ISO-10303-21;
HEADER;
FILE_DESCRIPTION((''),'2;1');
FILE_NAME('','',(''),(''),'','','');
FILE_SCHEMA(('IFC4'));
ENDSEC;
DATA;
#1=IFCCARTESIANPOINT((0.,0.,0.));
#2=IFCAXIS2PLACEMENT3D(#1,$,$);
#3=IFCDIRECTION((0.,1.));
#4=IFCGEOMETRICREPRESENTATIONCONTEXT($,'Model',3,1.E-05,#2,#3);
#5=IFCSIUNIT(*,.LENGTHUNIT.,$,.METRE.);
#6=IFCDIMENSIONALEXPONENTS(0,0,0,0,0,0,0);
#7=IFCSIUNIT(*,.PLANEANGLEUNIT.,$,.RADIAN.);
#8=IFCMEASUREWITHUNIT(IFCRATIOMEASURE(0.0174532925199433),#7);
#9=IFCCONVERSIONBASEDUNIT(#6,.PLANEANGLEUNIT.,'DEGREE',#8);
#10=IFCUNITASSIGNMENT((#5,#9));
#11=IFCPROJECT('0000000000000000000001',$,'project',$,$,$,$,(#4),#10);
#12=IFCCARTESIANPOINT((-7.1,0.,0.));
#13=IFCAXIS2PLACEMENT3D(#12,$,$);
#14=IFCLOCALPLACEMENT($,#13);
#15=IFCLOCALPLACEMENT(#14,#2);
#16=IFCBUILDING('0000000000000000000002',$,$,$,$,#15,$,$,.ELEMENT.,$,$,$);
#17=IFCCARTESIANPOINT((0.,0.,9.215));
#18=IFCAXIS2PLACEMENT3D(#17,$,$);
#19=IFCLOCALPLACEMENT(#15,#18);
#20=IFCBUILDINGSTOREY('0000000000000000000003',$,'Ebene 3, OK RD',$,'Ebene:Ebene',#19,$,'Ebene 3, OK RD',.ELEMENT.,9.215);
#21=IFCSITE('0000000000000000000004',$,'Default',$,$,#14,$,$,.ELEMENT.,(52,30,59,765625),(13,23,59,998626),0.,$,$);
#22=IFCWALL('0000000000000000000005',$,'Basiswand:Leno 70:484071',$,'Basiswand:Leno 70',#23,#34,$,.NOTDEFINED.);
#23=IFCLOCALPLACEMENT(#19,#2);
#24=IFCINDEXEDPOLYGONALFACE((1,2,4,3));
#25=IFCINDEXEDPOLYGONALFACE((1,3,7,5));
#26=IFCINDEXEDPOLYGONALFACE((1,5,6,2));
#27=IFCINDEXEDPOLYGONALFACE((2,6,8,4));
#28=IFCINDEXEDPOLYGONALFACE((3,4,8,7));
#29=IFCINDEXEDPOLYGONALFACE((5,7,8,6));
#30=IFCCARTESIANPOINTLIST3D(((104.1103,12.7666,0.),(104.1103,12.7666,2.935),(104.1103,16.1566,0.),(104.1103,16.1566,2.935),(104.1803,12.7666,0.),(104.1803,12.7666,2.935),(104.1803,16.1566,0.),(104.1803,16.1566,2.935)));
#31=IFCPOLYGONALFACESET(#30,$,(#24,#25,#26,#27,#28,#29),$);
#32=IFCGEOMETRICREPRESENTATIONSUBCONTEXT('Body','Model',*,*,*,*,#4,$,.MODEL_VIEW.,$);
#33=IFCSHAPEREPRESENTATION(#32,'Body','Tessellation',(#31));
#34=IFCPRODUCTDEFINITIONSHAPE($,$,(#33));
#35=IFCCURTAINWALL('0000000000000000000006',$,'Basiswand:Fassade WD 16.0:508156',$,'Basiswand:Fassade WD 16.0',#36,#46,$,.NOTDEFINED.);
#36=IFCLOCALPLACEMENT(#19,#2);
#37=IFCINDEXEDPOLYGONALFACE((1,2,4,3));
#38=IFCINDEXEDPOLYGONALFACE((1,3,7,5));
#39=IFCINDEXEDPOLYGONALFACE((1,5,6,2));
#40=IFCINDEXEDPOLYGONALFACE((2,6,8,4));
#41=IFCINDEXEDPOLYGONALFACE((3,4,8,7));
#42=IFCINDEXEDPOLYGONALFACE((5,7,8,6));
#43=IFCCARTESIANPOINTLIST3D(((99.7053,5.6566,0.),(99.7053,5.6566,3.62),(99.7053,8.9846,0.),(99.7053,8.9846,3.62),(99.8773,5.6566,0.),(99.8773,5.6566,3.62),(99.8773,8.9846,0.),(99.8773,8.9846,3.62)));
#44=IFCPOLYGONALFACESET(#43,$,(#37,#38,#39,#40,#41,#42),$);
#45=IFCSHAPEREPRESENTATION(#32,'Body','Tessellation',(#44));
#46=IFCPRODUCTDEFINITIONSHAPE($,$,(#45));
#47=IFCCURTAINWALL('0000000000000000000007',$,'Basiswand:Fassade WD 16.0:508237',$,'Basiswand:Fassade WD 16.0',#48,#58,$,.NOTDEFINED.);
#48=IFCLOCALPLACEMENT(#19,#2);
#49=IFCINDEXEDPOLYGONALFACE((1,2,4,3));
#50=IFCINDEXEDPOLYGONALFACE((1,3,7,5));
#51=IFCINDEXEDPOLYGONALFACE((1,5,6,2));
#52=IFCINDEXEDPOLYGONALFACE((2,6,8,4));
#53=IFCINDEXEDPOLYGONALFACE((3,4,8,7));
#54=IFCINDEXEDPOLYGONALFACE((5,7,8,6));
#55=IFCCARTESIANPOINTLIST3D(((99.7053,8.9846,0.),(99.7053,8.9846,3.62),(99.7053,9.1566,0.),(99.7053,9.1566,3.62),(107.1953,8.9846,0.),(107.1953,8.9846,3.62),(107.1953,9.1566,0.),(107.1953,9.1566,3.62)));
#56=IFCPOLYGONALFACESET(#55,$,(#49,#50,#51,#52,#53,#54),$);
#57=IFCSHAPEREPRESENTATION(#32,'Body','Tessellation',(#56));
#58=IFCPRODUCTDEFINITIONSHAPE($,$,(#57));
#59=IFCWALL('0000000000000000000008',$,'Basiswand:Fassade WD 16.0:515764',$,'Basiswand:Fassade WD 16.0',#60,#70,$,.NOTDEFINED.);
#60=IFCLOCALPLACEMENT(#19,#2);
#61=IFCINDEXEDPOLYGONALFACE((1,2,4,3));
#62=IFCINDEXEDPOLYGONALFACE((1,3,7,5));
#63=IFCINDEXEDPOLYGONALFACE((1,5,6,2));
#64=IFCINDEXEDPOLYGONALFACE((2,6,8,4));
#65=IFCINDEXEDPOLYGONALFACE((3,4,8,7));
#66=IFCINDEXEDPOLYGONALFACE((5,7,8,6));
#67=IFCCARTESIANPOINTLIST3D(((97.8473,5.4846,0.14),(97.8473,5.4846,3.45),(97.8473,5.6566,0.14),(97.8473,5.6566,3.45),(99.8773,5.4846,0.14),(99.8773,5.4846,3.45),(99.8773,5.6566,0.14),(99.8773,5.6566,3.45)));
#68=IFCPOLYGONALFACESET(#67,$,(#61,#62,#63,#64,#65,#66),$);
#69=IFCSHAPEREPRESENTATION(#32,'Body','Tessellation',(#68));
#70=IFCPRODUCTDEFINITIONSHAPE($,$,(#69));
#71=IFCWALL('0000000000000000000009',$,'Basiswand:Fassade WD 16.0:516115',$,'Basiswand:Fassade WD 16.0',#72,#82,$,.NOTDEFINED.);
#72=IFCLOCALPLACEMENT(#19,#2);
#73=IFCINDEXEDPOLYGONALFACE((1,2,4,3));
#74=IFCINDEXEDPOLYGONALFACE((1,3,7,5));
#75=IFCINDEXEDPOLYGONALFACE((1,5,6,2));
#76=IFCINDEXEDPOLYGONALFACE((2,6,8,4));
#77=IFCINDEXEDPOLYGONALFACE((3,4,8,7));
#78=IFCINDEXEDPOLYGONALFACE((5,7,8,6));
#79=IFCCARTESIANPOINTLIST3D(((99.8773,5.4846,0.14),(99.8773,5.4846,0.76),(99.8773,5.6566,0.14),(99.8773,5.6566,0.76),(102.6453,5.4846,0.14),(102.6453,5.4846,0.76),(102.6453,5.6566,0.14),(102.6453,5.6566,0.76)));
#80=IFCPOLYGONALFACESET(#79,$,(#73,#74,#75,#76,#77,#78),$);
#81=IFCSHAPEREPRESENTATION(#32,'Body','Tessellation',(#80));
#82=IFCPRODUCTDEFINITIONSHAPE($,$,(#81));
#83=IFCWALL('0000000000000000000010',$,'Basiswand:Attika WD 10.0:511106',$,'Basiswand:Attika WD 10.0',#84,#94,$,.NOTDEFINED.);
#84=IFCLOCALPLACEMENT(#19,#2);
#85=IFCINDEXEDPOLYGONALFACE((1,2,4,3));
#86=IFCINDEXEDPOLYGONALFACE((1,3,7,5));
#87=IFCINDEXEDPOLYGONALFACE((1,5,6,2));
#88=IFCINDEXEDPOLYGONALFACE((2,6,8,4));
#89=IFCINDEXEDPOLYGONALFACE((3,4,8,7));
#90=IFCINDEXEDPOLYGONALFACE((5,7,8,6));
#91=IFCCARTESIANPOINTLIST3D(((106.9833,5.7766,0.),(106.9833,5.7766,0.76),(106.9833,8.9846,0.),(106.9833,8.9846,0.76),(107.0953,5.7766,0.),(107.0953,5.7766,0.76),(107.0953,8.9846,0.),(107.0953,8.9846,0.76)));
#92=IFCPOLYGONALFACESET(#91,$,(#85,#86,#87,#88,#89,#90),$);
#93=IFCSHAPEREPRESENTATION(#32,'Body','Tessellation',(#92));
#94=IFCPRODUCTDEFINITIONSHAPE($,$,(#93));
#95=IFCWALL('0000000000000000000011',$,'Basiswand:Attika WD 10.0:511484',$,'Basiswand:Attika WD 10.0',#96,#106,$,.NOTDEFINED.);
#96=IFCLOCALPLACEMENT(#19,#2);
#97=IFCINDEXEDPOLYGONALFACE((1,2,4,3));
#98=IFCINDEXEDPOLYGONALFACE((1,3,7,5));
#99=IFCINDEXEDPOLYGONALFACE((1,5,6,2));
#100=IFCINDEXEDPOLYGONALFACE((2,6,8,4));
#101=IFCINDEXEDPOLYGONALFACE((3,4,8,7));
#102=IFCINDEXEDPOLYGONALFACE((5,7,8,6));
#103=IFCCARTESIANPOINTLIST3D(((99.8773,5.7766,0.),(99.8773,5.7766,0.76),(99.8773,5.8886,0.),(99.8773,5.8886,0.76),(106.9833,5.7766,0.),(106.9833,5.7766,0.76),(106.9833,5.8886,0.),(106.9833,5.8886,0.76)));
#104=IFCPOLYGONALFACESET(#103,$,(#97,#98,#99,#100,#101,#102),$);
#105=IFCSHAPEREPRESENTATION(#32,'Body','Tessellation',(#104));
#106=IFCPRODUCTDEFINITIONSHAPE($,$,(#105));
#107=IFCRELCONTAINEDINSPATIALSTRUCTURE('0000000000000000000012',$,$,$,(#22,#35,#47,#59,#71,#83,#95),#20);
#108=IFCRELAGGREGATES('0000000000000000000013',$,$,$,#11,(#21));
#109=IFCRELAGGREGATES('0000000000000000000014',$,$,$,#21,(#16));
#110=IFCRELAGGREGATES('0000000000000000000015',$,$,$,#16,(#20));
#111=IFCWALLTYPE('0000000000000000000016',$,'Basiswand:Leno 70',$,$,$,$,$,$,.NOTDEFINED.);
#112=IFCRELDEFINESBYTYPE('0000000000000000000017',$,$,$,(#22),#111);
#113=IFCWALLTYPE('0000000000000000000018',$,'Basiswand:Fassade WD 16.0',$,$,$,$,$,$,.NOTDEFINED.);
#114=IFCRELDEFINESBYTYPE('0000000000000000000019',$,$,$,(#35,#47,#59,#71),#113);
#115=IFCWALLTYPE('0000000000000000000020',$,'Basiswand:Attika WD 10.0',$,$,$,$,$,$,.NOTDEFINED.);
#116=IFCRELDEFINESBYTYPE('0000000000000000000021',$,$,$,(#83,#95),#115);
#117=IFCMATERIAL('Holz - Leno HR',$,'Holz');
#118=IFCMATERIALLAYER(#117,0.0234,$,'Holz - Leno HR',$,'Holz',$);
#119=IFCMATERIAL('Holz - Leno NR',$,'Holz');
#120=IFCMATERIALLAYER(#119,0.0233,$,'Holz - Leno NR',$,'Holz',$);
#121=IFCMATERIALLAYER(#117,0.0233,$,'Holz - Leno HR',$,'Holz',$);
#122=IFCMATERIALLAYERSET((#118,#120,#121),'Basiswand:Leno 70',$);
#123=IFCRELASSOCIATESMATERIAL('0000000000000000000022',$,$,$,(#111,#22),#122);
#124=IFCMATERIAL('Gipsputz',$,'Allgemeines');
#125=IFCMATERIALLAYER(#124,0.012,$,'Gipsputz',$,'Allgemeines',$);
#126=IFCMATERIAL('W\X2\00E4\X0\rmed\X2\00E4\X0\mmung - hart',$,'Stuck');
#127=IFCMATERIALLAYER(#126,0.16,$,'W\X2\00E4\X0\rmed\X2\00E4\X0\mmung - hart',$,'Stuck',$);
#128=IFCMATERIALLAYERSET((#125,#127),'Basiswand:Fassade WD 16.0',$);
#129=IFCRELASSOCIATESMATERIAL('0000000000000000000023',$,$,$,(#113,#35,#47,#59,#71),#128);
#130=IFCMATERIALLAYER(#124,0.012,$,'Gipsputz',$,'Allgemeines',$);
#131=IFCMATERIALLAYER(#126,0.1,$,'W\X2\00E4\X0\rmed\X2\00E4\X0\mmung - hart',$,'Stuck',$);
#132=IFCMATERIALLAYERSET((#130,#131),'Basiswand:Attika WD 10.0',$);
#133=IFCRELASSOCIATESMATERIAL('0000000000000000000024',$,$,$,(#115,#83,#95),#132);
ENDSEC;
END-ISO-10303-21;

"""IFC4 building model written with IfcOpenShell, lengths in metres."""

from ifc_helpers import new_model, entity, si_unit, converted_unit, direction, frame, frame_2d, origin, place, context, subcontext, project, spatial, rectangle, extrude, material, layer, layer_set, layer_usage, type_object, element, save


model = new_model("IFC4")

# Units and contexts
model_context = context("Model", 3, precision=1e-05, world=origin(), true_north=direction((0.0, 1.0)))
body_context = subcontext(model_context, "Body", "Model", "MODEL_VIEW")
ifc_project = project(units=[si_unit("LENGTHUNIT", "METRE"), converted_unit("PLANEANGLEUNIT", "DEGREE", entity("IfcRatioMeasure", 0.0174532925199433), si_unit("PLANEANGLEUNIT", "RADIAN"), dimensions=[0, 0, 0, 0, 0, 0, 0])], contexts=[model_context])

# Site, building, storey
site_placement = place(None, frame((-7.1, 0.0, 0.0)))
site = spatial("IfcSite", under=ifc_project, at=site_placement, Name="Default", CompositionType="ELEMENT", RefLatitude=(52, 30, 59, 765625), RefLongitude=(13, 23, 59, 998626), RefElevation=0.0)
building_placement = place(site_placement, origin())
building = spatial("IfcBuilding", under=site, at=building_placement, CompositionType="ELEMENT")
storey_placement = place(building_placement, frame((0.0, 0.0, 9.215)))
storey = spatial("IfcBuildingStorey", under=building, at=storey_placement, Name="Ebene 3, OK RD", ObjectType="Ebene:Ebene", LongName="Ebene 3, OK RD", CompositionType="ELEMENT", Elevation=9.215)

# Shared definitions
ifc_material_1 = material(Name="Holz - Leno HR", Category="Holz")
ifc_material_2 = material(Name="Holz - Leno NR", Category="Holz")
ifc_material_3 = material(Name="Wärmedämmung - hart", Category="Stuck")

# Wall
ifc_layer_1 = layer(ifc_material_1, 0.0234, Name="Holz - Leno HR", Category="Holz")
ifc_layer_2 = layer(ifc_material_2, 0.0233, Name="Holz - Leno NR", Category="Holz")
ifc_layer_3 = layer(ifc_material_1, 0.0233, Name="Holz - Leno HR", Category="Holz")
ifc_layer_set_1 = layer_set([ifc_layer_1, ifc_layer_2, ifc_layer_3], Name="Basiswand:Leno 70")
wall_type_1 = type_object("IfcWallType", Name="Basiswand:Leno 70", PredefinedType="NOTDEFINED", material=ifc_layer_set_1)
ifc_layer_usage_1 = layer_usage(ifc_layer_set_1, "AXIS2", "NEGATIVE", 0.035)
wall_1_placement = place(storey_placement, frame((104.1453, 12.7666, 0.0), z_axis=(0.0, 0.0, 1.0), x_axis=(0.0, 1.0, 0.0)))
element("IfcWall", 1, at=wall_1_placement, inside=storey, type_object=wall_type_1, material=ifc_layer_usage_1, Name="Basiswand:Leno 70:484071", ObjectType="Basiswand:Leno 70", PredefinedType="NOTDEFINED", context=body_context, shape_type="SweptSolid", body=[
    extrude(rectangle(XDim=3.39, YDim=0.07, at=frame_2d((1.695, 0.0), x_axis=(-1.0, 0.0))), origin(), (0.0, 0.0, 1.0), 2.935),
])

# Curtain walls
ifc_material_4 = material(Name="Gipsputz", Category="Allgemeines")
ifc_layer_4 = layer(ifc_material_4, 0.012, Name="Gipsputz", Category="Allgemeines")
ifc_layer_5 = layer(ifc_material_3, 0.16, Name="Wärmedämmung - hart", Category="Stuck")
ifc_layer_set_2 = layer_set([ifc_layer_4, ifc_layer_5], Name="Basiswand:Fassade WD 16.0")
ifc_layer_usage_2 = layer_usage(ifc_layer_set_2, "AXIS2", "NEGATIVE", 0.086)
wall_type_2 = type_object("IfcWallType", Name="Basiswand:Fassade WD 16.0", PredefinedType="NOTDEFINED", material=ifc_layer_set_2)
curtain_wall_1_placement = place(storey_placement, frame((99.7913, 8.9846, 0.0), z_axis=(0.0, 0.0, 1.0), x_axis=(0.0, -1.0, 0.0)))
element("IfcCurtainWall", 2, at=curtain_wall_1_placement, inside=storey, type_object=wall_type_2, material=ifc_layer_usage_2, Name="Basiswand:Fassade WD 16.0:508156", ObjectType="Basiswand:Fassade WD 16.0", PredefinedType="NOTDEFINED", context=body_context, shape_type="SweptSolid", body=[
    extrude(rectangle(XDim=3.328, YDim=0.172, at=frame_2d((1.664, 0.0), x_axis=(-1.0, 0.0))), origin(), (0.0, 0.0, 1.0), 3.62),
])
ifc_layer_usage_3 = layer_usage(ifc_layer_set_2, "AXIS2", "POSITIVE", -0.086)
curtain_wall_2_placement = place(storey_placement, frame((99.7053, 9.0706, 0.0)))
element("IfcCurtainWall", 3, at=curtain_wall_2_placement, inside=storey, type_object=wall_type_2, material=ifc_layer_usage_3, Name="Basiswand:Fassade WD 16.0:508237", ObjectType="Basiswand:Fassade WD 16.0", PredefinedType="NOTDEFINED", context=body_context, shape_type="SweptSolid", body=[
    extrude(rectangle(XDim=7.49, YDim=0.172, at=frame_2d((3.745, 0.0), x_axis=(-1.0, 0.0))), origin(), (0.0, 0.0, 1.0), 3.62),
])

# Walls
ifc_layer_usage_4 = layer_usage(ifc_layer_set_2, "AXIS2", "NEGATIVE", 0.086)
wall_2_placement = place(storey_placement, frame((99.8773, 5.5706, 0.14), z_axis=(0.0, 0.0, 1.0), x_axis=(-1.0, 0.0, 0.0)))
element("IfcWall", 4, at=wall_2_placement, inside=storey, type_object=wall_type_2, material=ifc_layer_usage_4, Name="Basiswand:Fassade WD 16.0:515764", ObjectType="Basiswand:Fassade WD 16.0", PredefinedType="NOTDEFINED", context=body_context, shape_type="SweptSolid", body=[
    extrude(rectangle(XDim=2.03, YDim=0.172, at=frame_2d((1.015, 0.0), x_axis=(-1.0, 0.0))), origin(), (0.0, 0.0, 1.0), 3.31),
])
ifc_layer_usage_5 = layer_usage(ifc_layer_set_2, "AXIS2", "NEGATIVE", 0.086)
wall_3_placement = place(storey_placement, frame((102.6453, 5.5706, 0.14), z_axis=(0.0, 0.0, 1.0), x_axis=(-1.0, 0.0, 0.0)))
element("IfcWall", 5, at=wall_3_placement, inside=storey, type_object=wall_type_2, material=ifc_layer_usage_5, Name="Basiswand:Fassade WD 16.0:516115", ObjectType="Basiswand:Fassade WD 16.0", PredefinedType="NOTDEFINED", context=body_context, shape_type="SweptSolid", body=[
    extrude(rectangle(XDim=2.768, YDim=0.172, at=frame_2d((1.384, 0.0), x_axis=(-1.0, 0.0))), origin(), (0.0, 0.0, 1.0), 0.62),
])
ifc_layer_6 = layer(ifc_material_4, 0.012, Name="Gipsputz", Category="Allgemeines")
ifc_layer_7 = layer(ifc_material_3, 0.1, Name="Wärmedämmung - hart", Category="Stuck")
ifc_layer_set_3 = layer_set([ifc_layer_6, ifc_layer_7], Name="Basiswand:Attika WD 10.0")
ifc_layer_usage_6 = layer_usage(ifc_layer_set_3, "AXIS2", "POSITIVE", -0.056)
wall_type_3 = type_object("IfcWallType", Name="Basiswand:Attika WD 10.0", PredefinedType="NOTDEFINED", material=ifc_layer_set_3)
wall_4_placement = place(storey_placement, frame((107.0393, 8.9846, 0.0), z_axis=(0.0, 0.0, 1.0), x_axis=(0.0, -1.0, 0.0)))
element("IfcWall", 6, at=wall_4_placement, inside=storey, type_object=wall_type_3, material=ifc_layer_usage_6, Name="Basiswand:Attika WD 10.0:511106", ObjectType="Basiswand:Attika WD 10.0", PredefinedType="NOTDEFINED", context=body_context, shape_type="SweptSolid", body=[
    extrude(rectangle(XDim=3.208, YDim=0.112, at=frame_2d((1.604, 0.0), x_axis=(-1.0, 0.0))), origin(), (0.0, 0.0, 1.0), 0.76),
])
ifc_layer_usage_7 = layer_usage(ifc_layer_set_3, "AXIS2", "NEGATIVE", 0.056)
wall_5_placement = place(storey_placement, frame((99.8773, 5.8326, 0.0)))
element("IfcWall", 7, at=wall_5_placement, inside=storey, type_object=wall_type_3, material=ifc_layer_usage_7, Name="Basiswand:Attika WD 10.0:511484", ObjectType="Basiswand:Attika WD 10.0", PredefinedType="NOTDEFINED", context=body_context, shape_type="SweptSolid", body=[
    extrude(rectangle(XDim=7.106, YDim=0.112, at=frame_2d((3.553, 0.0), x_axis=(-1.0, 0.0))), origin(), (0.0, 0.0, 1.0), 0.76),
])

save(model, "model.ifc")
